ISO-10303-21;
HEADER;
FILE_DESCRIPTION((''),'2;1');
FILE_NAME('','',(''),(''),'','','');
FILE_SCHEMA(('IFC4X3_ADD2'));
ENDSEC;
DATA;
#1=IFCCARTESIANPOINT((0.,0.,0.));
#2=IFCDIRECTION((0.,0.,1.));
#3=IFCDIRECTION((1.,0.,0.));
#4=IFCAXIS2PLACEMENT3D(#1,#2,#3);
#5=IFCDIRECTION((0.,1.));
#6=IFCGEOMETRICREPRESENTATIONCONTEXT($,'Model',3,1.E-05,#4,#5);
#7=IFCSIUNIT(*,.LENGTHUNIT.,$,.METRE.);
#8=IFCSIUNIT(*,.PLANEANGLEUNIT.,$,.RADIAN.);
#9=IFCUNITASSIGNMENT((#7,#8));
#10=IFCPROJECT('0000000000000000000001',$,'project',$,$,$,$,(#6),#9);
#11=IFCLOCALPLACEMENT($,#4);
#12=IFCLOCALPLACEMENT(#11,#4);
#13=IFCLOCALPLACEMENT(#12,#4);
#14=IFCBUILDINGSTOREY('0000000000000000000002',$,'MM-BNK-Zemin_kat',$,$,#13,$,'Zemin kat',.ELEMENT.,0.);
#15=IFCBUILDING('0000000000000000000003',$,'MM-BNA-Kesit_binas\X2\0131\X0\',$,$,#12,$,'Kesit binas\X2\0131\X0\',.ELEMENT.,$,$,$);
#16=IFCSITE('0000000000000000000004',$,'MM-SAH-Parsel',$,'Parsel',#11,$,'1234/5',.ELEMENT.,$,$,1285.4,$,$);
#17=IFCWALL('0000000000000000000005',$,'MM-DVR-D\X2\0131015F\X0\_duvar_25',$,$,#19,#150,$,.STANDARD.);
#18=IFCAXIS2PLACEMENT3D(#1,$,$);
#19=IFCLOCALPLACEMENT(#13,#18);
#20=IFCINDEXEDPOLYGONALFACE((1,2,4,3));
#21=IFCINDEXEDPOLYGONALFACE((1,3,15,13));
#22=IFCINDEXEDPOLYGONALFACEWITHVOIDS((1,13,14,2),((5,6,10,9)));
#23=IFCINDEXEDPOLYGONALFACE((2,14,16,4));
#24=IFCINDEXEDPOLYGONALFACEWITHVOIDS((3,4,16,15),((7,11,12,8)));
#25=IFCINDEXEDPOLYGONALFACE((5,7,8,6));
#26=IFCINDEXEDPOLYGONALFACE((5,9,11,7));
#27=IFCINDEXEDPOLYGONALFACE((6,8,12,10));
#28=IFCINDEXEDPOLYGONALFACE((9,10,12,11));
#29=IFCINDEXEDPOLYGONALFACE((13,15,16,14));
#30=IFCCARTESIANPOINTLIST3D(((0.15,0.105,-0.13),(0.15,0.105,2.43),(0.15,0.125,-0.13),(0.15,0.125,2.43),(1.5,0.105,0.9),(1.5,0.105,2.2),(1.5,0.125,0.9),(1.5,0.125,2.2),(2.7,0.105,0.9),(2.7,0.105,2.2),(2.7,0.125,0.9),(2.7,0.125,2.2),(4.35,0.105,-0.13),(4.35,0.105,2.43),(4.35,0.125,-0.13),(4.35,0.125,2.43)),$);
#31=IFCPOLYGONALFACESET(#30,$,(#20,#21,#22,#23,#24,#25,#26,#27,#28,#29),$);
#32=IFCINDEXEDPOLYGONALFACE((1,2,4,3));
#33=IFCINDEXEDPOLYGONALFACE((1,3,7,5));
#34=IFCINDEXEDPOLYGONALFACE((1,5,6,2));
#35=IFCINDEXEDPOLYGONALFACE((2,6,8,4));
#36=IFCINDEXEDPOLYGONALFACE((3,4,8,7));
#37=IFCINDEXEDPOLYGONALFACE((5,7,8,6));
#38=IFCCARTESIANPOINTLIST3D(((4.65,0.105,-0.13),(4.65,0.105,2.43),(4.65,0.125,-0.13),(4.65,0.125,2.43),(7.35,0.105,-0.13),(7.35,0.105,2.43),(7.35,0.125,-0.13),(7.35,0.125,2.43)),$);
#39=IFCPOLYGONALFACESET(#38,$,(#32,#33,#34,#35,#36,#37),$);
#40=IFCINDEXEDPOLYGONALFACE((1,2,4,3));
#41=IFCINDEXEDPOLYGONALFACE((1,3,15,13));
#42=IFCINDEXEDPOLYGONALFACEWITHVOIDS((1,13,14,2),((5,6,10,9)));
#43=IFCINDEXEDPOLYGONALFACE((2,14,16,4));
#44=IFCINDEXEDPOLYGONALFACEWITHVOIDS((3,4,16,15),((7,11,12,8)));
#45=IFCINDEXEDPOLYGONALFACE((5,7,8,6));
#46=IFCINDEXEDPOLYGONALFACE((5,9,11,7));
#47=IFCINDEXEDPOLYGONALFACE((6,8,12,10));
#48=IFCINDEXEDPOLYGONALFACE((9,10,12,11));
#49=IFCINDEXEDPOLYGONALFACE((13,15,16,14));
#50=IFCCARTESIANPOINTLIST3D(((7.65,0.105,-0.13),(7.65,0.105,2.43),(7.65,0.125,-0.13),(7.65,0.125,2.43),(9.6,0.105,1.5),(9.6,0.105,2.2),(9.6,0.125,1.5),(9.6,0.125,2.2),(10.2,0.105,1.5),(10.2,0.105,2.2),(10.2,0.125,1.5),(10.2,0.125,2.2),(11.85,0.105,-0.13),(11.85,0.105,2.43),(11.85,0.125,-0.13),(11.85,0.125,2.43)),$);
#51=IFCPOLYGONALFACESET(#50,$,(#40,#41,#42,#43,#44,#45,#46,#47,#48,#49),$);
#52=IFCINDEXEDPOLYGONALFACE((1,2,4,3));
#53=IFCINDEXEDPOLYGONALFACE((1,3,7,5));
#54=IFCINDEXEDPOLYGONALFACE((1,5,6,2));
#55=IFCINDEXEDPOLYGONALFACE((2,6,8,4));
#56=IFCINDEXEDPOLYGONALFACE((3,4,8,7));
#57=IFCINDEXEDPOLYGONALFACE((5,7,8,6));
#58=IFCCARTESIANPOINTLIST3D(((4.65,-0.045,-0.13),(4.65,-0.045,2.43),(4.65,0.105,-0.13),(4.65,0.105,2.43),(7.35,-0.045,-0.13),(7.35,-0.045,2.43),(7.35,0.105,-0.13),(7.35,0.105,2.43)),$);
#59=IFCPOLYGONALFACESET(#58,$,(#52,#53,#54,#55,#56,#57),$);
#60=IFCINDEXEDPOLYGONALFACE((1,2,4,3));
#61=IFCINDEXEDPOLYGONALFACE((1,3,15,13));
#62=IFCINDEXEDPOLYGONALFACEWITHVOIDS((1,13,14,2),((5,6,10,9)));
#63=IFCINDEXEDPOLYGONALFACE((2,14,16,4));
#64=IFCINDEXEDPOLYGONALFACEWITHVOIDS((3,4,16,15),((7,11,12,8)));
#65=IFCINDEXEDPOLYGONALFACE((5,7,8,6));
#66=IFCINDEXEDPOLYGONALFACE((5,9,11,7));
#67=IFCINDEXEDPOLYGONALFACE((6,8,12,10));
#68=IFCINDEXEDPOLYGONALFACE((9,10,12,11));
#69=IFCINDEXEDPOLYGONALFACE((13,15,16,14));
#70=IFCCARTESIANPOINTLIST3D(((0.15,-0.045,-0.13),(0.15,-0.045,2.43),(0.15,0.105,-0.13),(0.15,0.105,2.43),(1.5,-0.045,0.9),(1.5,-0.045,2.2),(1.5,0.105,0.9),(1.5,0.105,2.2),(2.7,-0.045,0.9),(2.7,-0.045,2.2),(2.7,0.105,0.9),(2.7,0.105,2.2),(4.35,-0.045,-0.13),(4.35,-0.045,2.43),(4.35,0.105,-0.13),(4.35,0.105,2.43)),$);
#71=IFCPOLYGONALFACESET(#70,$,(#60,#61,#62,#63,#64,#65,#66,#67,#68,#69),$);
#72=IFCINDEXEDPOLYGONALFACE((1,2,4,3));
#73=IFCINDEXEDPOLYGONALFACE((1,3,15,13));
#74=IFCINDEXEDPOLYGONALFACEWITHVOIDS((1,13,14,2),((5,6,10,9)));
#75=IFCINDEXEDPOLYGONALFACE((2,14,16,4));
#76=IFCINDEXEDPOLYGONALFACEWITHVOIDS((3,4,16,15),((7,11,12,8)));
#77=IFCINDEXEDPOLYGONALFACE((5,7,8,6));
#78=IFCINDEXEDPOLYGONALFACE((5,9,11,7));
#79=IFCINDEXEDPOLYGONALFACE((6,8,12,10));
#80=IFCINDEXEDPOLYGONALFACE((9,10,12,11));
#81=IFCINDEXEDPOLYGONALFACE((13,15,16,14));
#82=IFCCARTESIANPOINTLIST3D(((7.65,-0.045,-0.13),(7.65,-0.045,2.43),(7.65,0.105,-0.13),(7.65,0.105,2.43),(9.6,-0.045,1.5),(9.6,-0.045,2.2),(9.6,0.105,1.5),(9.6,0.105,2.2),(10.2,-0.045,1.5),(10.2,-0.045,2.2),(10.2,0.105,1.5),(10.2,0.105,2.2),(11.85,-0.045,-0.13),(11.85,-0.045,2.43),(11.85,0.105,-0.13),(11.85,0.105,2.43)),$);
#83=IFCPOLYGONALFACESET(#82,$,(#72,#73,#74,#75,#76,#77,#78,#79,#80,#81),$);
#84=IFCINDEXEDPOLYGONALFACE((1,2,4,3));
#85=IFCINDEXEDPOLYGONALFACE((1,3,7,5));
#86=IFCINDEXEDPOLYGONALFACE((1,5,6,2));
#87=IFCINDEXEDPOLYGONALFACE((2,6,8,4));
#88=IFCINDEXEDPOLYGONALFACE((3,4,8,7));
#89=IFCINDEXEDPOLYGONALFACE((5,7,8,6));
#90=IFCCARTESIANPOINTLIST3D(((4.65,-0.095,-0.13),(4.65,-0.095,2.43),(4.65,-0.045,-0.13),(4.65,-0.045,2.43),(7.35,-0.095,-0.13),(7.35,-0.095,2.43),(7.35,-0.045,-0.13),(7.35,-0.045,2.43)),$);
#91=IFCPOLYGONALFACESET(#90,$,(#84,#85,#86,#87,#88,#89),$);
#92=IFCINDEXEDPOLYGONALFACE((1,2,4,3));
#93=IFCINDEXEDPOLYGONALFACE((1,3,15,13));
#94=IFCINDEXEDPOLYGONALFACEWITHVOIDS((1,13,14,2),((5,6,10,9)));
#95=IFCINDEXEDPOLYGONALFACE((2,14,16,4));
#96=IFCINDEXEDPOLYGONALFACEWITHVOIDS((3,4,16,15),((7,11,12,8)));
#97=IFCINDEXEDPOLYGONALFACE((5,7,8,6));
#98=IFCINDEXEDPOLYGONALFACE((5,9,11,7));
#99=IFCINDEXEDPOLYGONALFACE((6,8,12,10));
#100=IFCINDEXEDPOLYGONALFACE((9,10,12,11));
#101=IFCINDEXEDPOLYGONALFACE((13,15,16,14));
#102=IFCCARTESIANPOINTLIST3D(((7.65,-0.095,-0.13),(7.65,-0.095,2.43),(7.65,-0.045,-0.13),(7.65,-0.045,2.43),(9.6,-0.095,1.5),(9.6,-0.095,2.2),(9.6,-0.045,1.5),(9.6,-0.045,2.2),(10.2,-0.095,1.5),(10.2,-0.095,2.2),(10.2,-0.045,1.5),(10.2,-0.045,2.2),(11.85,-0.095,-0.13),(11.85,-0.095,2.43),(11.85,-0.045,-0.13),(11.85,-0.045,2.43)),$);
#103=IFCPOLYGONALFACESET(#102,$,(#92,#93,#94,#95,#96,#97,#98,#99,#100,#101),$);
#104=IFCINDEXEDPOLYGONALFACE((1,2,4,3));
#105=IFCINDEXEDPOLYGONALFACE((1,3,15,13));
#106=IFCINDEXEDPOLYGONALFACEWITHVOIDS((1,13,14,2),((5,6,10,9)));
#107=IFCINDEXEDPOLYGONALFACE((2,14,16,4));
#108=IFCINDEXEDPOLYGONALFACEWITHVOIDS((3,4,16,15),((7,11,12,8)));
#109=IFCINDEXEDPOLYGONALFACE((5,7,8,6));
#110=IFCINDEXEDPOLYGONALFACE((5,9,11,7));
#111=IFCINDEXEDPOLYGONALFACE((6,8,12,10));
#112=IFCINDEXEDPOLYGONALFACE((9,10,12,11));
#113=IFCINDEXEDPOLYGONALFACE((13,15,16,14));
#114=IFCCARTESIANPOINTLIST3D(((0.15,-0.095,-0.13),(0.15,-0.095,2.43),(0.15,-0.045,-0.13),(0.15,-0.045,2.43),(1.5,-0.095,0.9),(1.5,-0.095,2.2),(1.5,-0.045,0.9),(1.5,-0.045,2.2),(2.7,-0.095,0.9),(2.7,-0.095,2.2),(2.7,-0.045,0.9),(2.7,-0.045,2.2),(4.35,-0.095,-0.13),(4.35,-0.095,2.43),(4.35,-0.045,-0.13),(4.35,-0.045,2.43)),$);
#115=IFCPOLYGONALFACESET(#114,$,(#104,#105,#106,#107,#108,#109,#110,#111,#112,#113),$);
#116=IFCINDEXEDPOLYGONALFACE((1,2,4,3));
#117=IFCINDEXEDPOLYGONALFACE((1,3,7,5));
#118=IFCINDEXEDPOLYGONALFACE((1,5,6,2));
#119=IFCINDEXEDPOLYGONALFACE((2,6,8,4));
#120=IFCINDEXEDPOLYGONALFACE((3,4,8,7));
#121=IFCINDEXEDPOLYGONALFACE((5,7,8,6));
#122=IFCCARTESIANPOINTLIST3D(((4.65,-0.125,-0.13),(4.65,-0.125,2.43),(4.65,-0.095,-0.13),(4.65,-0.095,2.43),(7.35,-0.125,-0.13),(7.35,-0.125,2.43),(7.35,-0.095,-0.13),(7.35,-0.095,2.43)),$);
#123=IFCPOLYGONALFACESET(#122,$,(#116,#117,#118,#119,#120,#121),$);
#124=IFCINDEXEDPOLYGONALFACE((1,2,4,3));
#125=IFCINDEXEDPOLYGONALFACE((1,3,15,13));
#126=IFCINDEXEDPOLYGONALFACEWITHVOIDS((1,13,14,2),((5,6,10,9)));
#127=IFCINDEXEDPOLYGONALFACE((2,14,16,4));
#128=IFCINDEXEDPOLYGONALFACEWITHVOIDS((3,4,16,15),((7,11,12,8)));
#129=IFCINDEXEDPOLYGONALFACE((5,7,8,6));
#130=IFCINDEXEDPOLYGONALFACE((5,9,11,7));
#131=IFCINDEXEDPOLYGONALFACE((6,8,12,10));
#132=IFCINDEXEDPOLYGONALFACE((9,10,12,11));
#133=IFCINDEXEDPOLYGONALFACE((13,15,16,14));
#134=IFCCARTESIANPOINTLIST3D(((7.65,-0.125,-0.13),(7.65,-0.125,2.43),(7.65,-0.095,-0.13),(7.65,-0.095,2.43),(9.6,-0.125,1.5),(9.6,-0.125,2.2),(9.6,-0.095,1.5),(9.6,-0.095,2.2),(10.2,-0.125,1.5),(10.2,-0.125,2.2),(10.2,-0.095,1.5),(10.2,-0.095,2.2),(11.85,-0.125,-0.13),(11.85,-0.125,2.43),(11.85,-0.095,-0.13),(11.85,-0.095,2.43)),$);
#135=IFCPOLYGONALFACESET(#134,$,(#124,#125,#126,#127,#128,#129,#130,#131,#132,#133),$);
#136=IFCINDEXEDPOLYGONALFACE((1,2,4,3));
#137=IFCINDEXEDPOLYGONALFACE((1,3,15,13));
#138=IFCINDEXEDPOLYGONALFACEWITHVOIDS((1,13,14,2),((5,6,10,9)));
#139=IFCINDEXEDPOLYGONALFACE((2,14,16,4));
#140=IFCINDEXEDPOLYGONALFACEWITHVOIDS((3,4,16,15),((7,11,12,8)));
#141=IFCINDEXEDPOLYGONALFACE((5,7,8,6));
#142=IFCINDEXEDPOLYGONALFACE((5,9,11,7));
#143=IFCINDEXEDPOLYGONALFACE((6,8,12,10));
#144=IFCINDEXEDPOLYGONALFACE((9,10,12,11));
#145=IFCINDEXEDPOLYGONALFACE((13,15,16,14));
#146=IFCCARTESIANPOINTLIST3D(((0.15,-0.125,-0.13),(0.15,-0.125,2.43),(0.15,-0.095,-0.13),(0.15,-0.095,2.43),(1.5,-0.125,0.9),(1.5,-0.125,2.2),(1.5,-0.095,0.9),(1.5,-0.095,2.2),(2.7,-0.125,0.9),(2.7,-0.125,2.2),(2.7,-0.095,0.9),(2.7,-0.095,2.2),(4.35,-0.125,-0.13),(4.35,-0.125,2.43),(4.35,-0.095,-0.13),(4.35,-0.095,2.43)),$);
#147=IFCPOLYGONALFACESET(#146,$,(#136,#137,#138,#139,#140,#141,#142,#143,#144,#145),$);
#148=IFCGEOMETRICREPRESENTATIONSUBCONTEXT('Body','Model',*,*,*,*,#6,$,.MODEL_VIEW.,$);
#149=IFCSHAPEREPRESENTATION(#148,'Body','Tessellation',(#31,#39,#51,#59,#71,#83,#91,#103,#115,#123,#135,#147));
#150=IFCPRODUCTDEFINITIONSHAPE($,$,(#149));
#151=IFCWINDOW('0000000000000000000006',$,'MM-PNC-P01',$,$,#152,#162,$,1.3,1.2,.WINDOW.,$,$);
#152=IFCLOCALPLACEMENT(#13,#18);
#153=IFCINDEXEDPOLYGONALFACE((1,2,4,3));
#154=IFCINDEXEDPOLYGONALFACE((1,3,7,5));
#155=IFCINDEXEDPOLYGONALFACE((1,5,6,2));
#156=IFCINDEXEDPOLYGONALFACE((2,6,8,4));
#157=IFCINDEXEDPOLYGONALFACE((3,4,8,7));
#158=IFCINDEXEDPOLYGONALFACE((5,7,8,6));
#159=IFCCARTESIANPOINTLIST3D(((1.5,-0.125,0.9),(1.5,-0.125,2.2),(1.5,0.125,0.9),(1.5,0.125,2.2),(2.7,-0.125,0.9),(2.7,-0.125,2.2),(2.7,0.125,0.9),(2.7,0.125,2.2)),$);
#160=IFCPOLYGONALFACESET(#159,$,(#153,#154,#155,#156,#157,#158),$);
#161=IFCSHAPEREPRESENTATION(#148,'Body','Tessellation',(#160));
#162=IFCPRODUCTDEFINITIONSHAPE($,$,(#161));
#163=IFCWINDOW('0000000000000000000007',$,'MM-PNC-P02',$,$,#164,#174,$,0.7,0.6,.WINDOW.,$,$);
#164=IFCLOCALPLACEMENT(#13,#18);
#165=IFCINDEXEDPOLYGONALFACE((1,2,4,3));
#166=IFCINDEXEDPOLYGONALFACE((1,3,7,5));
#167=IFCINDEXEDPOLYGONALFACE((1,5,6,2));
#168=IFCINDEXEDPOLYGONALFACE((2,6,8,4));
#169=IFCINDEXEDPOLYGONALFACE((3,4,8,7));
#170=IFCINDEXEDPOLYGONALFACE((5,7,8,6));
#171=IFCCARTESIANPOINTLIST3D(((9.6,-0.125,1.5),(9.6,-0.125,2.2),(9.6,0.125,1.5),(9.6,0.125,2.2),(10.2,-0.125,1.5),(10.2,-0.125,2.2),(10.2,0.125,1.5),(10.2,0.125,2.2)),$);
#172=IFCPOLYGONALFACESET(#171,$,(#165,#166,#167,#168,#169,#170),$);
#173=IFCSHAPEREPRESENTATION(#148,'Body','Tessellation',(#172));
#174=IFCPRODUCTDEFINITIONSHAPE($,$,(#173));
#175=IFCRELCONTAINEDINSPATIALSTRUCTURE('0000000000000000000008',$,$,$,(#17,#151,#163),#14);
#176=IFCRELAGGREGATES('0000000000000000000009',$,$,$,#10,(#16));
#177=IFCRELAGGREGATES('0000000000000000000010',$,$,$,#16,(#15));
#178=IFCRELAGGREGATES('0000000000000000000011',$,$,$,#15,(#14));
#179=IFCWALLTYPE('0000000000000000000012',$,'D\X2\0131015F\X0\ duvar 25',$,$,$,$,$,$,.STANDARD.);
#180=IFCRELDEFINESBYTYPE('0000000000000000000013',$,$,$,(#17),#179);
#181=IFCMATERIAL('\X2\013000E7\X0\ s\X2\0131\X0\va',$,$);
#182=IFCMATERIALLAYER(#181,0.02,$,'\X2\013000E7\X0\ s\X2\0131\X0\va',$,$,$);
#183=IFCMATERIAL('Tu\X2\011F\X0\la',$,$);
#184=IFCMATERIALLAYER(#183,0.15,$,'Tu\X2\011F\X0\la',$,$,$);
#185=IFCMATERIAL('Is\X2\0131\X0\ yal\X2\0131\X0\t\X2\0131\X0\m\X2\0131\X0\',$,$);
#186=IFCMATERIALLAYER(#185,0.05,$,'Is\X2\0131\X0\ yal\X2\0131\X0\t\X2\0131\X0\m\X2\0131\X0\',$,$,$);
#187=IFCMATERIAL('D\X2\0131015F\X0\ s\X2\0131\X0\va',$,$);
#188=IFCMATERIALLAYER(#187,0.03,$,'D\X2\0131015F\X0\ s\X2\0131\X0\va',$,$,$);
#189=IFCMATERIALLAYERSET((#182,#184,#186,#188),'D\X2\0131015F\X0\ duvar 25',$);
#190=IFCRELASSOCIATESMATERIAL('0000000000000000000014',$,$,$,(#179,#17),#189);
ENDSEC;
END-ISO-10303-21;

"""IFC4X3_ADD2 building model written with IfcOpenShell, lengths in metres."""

from ifc_helpers import new_model, si_unit, direction, frame, origin_with_axes, place, context, subcontext, project, spatial, polyline, outline, extrude, material, layer, layer_set, type_object, element, fill, save


model = new_model("IFC4X3_ADD2")

# Units and contexts
model_context = context("Model", 3, precision=1e-05, world=origin_with_axes(), true_north=direction((0.0, 1.0)))
body_context = subcontext(model_context, "Body", "Model", "MODEL_VIEW")
ifc_project = project(units=[si_unit("LENGTHUNIT", "METRE"), si_unit("PLANEANGLEUNIT", "RADIAN")], contexts=[model_context])

# Site, building, storey
site_placement = place(None, origin_with_axes())
site = spatial("IfcSite", under=ifc_project, at=site_placement, Name="MM-SAH-Parsel", ObjectType="Parsel", LongName="1234/5", CompositionType="ELEMENT", RefElevation=1285.4)
building_placement = place(site_placement, origin_with_axes())
building = spatial("IfcBuilding", under=site, at=building_placement, Name="MM-BNA-Kesit_binası", LongName="Kesit binası", CompositionType="ELEMENT")
storey_placement = place(building_placement, origin_with_axes())
storey = spatial("IfcBuildingStorey", under=building, at=storey_placement, Name="MM-BNK-Zemin_kat", LongName="Zemin kat", CompositionType="ELEMENT", Elevation=0.0)

# Wall, openings, windows
ifc_material_1 = material(Name="İç sıva")
ifc_layer_1 = layer(ifc_material_1, 0.02, Name="İç sıva")
ifc_material_2 = material(Name="Tuğla")
ifc_layer_2 = layer(ifc_material_2, 0.15, Name="Tuğla")
ifc_material_3 = material(Name="Isı yalıtımı")
ifc_layer_3 = layer(ifc_material_3, 0.05, Name="Isı yalıtımı")
ifc_material_4 = material(Name="Dış sıva")
ifc_layer_4 = layer(ifc_material_4, 0.03, Name="Dış sıva")
ifc_layer_set_1 = layer_set([ifc_layer_1, ifc_layer_2, ifc_layer_3, ifc_layer_4], Name="Dış duvar 25")
wall_type_1 = type_object("IfcWallType", Name="Dış duvar 25", PredefinedType="STANDARD", material=ifc_layer_set_1)
wall_1_placement = place(storey_placement, origin_with_axes())
wall_1 = element("IfcWall", 1, at=wall_1_placement, inside=storey, type_object=wall_type_1, material=ifc_layer_set_1, Name="MM-DVR-Dış_duvar_25", PredefinedType="STANDARD", context=body_context, shape_type="SweptSolid", body=[
    extrude(outline(polyline([(0.15, 0.105), (4.35, 0.105), (4.35, 0.125), (0.15, 0.125), (0.15, 0.105)])), frame((0.0, 0.0, -0.13)), (0.0, 0.0, 1.0), 2.56),
    extrude(outline(polyline([(4.65, 0.105), (7.35, 0.105), (7.35, 0.125), (4.65, 0.125), (4.65, 0.105)])), frame((0.0, 0.0, -0.13)), (0.0, 0.0, 1.0), 2.56),
    extrude(outline(polyline([(7.65, 0.105), (11.85, 0.105), (11.85, 0.125), (7.65, 0.125), (7.65, 0.105)])), frame((0.0, 0.0, -0.13)), (0.0, 0.0, 1.0), 2.56),
    extrude(outline(polyline([(4.65, -0.045), (7.35, -0.045), (7.35, 0.105), (4.65, 0.105), (4.65, -0.045)])), frame((0.0, 0.0, -0.13)), (0.0, 0.0, 1.0), 2.56),
    extrude(outline(polyline([(0.15, -0.045), (4.35, -0.045), (4.35, 0.105), (0.15, 0.105), (0.15, -0.045)])), frame((0.0, 0.0, -0.13)), (0.0, 0.0, 1.0), 2.56),
    extrude(outline(polyline([(7.65, -0.045), (11.85, -0.045), (11.85, 0.105), (7.65, 0.105), (7.65, -0.045)])), frame((0.0, 0.0, -0.13)), (0.0, 0.0, 1.0), 2.56),
    extrude(outline(polyline([(4.65, -0.095), (7.35, -0.095), (7.35, -0.045), (4.65, -0.045), (4.65, -0.095)])), frame((0.0, 0.0, -0.13)), (0.0, 0.0, 1.0), 2.56),
    extrude(outline(polyline([(7.65, -0.095), (11.85, -0.095), (11.85, -0.045), (7.65, -0.045), (7.65, -0.095)])), frame((0.0, 0.0, -0.13)), (0.0, 0.0, 1.0), 2.56),
    extrude(outline(polyline([(0.15, -0.095), (4.35, -0.095), (4.35, -0.045), (0.15, -0.045), (0.15, -0.095)])), frame((0.0, 0.0, -0.13)), (0.0, 0.0, 1.0), 2.56),
    extrude(outline(polyline([(4.65, -0.125), (7.35, -0.125), (7.35, -0.095), (4.65, -0.095), (4.65, -0.125)])), frame((0.0, 0.0, -0.13)), (0.0, 0.0, 1.0), 2.56),
    extrude(outline(polyline([(7.65, -0.125), (11.85, -0.125), (11.85, -0.095), (7.65, -0.095), (7.65, -0.125)])), frame((0.0, 0.0, -0.13)), (0.0, 0.0, 1.0), 2.56),
    extrude(outline(polyline([(0.15, -0.125), (4.35, -0.125), (4.35, -0.095), (0.15, -0.095), (0.15, -0.125)])), frame((0.0, 0.0, -0.13)), (0.0, 0.0, 1.0), 2.56),
])
opening_1_placement = place(storey_placement, origin_with_axes())
opening_1 = element("IfcOpeningElement", 2, at=opening_1_placement, cuts=wall_1, PredefinedType="OPENING", context=body_context, shape_type="SweptSolid", body=[
    extrude(outline(polyline([(1.5, 0.125), (2.7, 0.125), (2.7, -0.125), (1.5, -0.125), (1.5, 0.125)])), frame((0.0, 0.0, 0.9)), (0.0, 0.0, 1.0), 1.3),
])
opening_2_placement = place(storey_placement, origin_with_axes())
opening_2 = element("IfcOpeningElement", 3, at=opening_2_placement, cuts=wall_1, PredefinedType="OPENING", context=body_context, shape_type="SweptSolid", body=[
    extrude(outline(polyline([(9.6, 0.125), (10.2, 0.125), (10.2, -0.125), (9.6, -0.125), (9.6, 0.125)])), frame((0.0, 0.0, 1.5)), (0.0, 0.0, 1.0), 0.7),
])
window_1_placement = place(storey_placement, origin_with_axes())
window_1 = element("IfcWindow", 4, at=window_1_placement, inside=storey, Name="MM-PNC-P01", OverallHeight=1.3, OverallWidth=1.2, PredefinedType="WINDOW", context=body_context, shape_type="SweptSolid", body=[
    extrude(outline(polyline([(1.5, 0.125), (2.7, 0.125), (2.7, -0.125), (1.5, -0.125), (1.5, 0.125)])), frame((0.0, 0.0, 0.9)), (0.0, 0.0, 1.0), 1.3),
])
fill(opening_1, window_1)
window_2_placement = place(storey_placement, origin_with_axes())
window_2 = element("IfcWindow", 5, at=window_2_placement, inside=storey, Name="MM-PNC-P02", OverallHeight=0.7, OverallWidth=0.6, PredefinedType="WINDOW", context=body_context, shape_type="SweptSolid", body=[
    extrude(outline(polyline([(9.6, 0.125), (10.2, 0.125), (10.2, -0.125), (9.6, -0.125), (9.6, 0.125)])), frame((0.0, 0.0, 1.5)), (0.0, 0.0, 1.0), 0.7),
])
fill(opening_2, window_2)

save(model, "model.ifc")
